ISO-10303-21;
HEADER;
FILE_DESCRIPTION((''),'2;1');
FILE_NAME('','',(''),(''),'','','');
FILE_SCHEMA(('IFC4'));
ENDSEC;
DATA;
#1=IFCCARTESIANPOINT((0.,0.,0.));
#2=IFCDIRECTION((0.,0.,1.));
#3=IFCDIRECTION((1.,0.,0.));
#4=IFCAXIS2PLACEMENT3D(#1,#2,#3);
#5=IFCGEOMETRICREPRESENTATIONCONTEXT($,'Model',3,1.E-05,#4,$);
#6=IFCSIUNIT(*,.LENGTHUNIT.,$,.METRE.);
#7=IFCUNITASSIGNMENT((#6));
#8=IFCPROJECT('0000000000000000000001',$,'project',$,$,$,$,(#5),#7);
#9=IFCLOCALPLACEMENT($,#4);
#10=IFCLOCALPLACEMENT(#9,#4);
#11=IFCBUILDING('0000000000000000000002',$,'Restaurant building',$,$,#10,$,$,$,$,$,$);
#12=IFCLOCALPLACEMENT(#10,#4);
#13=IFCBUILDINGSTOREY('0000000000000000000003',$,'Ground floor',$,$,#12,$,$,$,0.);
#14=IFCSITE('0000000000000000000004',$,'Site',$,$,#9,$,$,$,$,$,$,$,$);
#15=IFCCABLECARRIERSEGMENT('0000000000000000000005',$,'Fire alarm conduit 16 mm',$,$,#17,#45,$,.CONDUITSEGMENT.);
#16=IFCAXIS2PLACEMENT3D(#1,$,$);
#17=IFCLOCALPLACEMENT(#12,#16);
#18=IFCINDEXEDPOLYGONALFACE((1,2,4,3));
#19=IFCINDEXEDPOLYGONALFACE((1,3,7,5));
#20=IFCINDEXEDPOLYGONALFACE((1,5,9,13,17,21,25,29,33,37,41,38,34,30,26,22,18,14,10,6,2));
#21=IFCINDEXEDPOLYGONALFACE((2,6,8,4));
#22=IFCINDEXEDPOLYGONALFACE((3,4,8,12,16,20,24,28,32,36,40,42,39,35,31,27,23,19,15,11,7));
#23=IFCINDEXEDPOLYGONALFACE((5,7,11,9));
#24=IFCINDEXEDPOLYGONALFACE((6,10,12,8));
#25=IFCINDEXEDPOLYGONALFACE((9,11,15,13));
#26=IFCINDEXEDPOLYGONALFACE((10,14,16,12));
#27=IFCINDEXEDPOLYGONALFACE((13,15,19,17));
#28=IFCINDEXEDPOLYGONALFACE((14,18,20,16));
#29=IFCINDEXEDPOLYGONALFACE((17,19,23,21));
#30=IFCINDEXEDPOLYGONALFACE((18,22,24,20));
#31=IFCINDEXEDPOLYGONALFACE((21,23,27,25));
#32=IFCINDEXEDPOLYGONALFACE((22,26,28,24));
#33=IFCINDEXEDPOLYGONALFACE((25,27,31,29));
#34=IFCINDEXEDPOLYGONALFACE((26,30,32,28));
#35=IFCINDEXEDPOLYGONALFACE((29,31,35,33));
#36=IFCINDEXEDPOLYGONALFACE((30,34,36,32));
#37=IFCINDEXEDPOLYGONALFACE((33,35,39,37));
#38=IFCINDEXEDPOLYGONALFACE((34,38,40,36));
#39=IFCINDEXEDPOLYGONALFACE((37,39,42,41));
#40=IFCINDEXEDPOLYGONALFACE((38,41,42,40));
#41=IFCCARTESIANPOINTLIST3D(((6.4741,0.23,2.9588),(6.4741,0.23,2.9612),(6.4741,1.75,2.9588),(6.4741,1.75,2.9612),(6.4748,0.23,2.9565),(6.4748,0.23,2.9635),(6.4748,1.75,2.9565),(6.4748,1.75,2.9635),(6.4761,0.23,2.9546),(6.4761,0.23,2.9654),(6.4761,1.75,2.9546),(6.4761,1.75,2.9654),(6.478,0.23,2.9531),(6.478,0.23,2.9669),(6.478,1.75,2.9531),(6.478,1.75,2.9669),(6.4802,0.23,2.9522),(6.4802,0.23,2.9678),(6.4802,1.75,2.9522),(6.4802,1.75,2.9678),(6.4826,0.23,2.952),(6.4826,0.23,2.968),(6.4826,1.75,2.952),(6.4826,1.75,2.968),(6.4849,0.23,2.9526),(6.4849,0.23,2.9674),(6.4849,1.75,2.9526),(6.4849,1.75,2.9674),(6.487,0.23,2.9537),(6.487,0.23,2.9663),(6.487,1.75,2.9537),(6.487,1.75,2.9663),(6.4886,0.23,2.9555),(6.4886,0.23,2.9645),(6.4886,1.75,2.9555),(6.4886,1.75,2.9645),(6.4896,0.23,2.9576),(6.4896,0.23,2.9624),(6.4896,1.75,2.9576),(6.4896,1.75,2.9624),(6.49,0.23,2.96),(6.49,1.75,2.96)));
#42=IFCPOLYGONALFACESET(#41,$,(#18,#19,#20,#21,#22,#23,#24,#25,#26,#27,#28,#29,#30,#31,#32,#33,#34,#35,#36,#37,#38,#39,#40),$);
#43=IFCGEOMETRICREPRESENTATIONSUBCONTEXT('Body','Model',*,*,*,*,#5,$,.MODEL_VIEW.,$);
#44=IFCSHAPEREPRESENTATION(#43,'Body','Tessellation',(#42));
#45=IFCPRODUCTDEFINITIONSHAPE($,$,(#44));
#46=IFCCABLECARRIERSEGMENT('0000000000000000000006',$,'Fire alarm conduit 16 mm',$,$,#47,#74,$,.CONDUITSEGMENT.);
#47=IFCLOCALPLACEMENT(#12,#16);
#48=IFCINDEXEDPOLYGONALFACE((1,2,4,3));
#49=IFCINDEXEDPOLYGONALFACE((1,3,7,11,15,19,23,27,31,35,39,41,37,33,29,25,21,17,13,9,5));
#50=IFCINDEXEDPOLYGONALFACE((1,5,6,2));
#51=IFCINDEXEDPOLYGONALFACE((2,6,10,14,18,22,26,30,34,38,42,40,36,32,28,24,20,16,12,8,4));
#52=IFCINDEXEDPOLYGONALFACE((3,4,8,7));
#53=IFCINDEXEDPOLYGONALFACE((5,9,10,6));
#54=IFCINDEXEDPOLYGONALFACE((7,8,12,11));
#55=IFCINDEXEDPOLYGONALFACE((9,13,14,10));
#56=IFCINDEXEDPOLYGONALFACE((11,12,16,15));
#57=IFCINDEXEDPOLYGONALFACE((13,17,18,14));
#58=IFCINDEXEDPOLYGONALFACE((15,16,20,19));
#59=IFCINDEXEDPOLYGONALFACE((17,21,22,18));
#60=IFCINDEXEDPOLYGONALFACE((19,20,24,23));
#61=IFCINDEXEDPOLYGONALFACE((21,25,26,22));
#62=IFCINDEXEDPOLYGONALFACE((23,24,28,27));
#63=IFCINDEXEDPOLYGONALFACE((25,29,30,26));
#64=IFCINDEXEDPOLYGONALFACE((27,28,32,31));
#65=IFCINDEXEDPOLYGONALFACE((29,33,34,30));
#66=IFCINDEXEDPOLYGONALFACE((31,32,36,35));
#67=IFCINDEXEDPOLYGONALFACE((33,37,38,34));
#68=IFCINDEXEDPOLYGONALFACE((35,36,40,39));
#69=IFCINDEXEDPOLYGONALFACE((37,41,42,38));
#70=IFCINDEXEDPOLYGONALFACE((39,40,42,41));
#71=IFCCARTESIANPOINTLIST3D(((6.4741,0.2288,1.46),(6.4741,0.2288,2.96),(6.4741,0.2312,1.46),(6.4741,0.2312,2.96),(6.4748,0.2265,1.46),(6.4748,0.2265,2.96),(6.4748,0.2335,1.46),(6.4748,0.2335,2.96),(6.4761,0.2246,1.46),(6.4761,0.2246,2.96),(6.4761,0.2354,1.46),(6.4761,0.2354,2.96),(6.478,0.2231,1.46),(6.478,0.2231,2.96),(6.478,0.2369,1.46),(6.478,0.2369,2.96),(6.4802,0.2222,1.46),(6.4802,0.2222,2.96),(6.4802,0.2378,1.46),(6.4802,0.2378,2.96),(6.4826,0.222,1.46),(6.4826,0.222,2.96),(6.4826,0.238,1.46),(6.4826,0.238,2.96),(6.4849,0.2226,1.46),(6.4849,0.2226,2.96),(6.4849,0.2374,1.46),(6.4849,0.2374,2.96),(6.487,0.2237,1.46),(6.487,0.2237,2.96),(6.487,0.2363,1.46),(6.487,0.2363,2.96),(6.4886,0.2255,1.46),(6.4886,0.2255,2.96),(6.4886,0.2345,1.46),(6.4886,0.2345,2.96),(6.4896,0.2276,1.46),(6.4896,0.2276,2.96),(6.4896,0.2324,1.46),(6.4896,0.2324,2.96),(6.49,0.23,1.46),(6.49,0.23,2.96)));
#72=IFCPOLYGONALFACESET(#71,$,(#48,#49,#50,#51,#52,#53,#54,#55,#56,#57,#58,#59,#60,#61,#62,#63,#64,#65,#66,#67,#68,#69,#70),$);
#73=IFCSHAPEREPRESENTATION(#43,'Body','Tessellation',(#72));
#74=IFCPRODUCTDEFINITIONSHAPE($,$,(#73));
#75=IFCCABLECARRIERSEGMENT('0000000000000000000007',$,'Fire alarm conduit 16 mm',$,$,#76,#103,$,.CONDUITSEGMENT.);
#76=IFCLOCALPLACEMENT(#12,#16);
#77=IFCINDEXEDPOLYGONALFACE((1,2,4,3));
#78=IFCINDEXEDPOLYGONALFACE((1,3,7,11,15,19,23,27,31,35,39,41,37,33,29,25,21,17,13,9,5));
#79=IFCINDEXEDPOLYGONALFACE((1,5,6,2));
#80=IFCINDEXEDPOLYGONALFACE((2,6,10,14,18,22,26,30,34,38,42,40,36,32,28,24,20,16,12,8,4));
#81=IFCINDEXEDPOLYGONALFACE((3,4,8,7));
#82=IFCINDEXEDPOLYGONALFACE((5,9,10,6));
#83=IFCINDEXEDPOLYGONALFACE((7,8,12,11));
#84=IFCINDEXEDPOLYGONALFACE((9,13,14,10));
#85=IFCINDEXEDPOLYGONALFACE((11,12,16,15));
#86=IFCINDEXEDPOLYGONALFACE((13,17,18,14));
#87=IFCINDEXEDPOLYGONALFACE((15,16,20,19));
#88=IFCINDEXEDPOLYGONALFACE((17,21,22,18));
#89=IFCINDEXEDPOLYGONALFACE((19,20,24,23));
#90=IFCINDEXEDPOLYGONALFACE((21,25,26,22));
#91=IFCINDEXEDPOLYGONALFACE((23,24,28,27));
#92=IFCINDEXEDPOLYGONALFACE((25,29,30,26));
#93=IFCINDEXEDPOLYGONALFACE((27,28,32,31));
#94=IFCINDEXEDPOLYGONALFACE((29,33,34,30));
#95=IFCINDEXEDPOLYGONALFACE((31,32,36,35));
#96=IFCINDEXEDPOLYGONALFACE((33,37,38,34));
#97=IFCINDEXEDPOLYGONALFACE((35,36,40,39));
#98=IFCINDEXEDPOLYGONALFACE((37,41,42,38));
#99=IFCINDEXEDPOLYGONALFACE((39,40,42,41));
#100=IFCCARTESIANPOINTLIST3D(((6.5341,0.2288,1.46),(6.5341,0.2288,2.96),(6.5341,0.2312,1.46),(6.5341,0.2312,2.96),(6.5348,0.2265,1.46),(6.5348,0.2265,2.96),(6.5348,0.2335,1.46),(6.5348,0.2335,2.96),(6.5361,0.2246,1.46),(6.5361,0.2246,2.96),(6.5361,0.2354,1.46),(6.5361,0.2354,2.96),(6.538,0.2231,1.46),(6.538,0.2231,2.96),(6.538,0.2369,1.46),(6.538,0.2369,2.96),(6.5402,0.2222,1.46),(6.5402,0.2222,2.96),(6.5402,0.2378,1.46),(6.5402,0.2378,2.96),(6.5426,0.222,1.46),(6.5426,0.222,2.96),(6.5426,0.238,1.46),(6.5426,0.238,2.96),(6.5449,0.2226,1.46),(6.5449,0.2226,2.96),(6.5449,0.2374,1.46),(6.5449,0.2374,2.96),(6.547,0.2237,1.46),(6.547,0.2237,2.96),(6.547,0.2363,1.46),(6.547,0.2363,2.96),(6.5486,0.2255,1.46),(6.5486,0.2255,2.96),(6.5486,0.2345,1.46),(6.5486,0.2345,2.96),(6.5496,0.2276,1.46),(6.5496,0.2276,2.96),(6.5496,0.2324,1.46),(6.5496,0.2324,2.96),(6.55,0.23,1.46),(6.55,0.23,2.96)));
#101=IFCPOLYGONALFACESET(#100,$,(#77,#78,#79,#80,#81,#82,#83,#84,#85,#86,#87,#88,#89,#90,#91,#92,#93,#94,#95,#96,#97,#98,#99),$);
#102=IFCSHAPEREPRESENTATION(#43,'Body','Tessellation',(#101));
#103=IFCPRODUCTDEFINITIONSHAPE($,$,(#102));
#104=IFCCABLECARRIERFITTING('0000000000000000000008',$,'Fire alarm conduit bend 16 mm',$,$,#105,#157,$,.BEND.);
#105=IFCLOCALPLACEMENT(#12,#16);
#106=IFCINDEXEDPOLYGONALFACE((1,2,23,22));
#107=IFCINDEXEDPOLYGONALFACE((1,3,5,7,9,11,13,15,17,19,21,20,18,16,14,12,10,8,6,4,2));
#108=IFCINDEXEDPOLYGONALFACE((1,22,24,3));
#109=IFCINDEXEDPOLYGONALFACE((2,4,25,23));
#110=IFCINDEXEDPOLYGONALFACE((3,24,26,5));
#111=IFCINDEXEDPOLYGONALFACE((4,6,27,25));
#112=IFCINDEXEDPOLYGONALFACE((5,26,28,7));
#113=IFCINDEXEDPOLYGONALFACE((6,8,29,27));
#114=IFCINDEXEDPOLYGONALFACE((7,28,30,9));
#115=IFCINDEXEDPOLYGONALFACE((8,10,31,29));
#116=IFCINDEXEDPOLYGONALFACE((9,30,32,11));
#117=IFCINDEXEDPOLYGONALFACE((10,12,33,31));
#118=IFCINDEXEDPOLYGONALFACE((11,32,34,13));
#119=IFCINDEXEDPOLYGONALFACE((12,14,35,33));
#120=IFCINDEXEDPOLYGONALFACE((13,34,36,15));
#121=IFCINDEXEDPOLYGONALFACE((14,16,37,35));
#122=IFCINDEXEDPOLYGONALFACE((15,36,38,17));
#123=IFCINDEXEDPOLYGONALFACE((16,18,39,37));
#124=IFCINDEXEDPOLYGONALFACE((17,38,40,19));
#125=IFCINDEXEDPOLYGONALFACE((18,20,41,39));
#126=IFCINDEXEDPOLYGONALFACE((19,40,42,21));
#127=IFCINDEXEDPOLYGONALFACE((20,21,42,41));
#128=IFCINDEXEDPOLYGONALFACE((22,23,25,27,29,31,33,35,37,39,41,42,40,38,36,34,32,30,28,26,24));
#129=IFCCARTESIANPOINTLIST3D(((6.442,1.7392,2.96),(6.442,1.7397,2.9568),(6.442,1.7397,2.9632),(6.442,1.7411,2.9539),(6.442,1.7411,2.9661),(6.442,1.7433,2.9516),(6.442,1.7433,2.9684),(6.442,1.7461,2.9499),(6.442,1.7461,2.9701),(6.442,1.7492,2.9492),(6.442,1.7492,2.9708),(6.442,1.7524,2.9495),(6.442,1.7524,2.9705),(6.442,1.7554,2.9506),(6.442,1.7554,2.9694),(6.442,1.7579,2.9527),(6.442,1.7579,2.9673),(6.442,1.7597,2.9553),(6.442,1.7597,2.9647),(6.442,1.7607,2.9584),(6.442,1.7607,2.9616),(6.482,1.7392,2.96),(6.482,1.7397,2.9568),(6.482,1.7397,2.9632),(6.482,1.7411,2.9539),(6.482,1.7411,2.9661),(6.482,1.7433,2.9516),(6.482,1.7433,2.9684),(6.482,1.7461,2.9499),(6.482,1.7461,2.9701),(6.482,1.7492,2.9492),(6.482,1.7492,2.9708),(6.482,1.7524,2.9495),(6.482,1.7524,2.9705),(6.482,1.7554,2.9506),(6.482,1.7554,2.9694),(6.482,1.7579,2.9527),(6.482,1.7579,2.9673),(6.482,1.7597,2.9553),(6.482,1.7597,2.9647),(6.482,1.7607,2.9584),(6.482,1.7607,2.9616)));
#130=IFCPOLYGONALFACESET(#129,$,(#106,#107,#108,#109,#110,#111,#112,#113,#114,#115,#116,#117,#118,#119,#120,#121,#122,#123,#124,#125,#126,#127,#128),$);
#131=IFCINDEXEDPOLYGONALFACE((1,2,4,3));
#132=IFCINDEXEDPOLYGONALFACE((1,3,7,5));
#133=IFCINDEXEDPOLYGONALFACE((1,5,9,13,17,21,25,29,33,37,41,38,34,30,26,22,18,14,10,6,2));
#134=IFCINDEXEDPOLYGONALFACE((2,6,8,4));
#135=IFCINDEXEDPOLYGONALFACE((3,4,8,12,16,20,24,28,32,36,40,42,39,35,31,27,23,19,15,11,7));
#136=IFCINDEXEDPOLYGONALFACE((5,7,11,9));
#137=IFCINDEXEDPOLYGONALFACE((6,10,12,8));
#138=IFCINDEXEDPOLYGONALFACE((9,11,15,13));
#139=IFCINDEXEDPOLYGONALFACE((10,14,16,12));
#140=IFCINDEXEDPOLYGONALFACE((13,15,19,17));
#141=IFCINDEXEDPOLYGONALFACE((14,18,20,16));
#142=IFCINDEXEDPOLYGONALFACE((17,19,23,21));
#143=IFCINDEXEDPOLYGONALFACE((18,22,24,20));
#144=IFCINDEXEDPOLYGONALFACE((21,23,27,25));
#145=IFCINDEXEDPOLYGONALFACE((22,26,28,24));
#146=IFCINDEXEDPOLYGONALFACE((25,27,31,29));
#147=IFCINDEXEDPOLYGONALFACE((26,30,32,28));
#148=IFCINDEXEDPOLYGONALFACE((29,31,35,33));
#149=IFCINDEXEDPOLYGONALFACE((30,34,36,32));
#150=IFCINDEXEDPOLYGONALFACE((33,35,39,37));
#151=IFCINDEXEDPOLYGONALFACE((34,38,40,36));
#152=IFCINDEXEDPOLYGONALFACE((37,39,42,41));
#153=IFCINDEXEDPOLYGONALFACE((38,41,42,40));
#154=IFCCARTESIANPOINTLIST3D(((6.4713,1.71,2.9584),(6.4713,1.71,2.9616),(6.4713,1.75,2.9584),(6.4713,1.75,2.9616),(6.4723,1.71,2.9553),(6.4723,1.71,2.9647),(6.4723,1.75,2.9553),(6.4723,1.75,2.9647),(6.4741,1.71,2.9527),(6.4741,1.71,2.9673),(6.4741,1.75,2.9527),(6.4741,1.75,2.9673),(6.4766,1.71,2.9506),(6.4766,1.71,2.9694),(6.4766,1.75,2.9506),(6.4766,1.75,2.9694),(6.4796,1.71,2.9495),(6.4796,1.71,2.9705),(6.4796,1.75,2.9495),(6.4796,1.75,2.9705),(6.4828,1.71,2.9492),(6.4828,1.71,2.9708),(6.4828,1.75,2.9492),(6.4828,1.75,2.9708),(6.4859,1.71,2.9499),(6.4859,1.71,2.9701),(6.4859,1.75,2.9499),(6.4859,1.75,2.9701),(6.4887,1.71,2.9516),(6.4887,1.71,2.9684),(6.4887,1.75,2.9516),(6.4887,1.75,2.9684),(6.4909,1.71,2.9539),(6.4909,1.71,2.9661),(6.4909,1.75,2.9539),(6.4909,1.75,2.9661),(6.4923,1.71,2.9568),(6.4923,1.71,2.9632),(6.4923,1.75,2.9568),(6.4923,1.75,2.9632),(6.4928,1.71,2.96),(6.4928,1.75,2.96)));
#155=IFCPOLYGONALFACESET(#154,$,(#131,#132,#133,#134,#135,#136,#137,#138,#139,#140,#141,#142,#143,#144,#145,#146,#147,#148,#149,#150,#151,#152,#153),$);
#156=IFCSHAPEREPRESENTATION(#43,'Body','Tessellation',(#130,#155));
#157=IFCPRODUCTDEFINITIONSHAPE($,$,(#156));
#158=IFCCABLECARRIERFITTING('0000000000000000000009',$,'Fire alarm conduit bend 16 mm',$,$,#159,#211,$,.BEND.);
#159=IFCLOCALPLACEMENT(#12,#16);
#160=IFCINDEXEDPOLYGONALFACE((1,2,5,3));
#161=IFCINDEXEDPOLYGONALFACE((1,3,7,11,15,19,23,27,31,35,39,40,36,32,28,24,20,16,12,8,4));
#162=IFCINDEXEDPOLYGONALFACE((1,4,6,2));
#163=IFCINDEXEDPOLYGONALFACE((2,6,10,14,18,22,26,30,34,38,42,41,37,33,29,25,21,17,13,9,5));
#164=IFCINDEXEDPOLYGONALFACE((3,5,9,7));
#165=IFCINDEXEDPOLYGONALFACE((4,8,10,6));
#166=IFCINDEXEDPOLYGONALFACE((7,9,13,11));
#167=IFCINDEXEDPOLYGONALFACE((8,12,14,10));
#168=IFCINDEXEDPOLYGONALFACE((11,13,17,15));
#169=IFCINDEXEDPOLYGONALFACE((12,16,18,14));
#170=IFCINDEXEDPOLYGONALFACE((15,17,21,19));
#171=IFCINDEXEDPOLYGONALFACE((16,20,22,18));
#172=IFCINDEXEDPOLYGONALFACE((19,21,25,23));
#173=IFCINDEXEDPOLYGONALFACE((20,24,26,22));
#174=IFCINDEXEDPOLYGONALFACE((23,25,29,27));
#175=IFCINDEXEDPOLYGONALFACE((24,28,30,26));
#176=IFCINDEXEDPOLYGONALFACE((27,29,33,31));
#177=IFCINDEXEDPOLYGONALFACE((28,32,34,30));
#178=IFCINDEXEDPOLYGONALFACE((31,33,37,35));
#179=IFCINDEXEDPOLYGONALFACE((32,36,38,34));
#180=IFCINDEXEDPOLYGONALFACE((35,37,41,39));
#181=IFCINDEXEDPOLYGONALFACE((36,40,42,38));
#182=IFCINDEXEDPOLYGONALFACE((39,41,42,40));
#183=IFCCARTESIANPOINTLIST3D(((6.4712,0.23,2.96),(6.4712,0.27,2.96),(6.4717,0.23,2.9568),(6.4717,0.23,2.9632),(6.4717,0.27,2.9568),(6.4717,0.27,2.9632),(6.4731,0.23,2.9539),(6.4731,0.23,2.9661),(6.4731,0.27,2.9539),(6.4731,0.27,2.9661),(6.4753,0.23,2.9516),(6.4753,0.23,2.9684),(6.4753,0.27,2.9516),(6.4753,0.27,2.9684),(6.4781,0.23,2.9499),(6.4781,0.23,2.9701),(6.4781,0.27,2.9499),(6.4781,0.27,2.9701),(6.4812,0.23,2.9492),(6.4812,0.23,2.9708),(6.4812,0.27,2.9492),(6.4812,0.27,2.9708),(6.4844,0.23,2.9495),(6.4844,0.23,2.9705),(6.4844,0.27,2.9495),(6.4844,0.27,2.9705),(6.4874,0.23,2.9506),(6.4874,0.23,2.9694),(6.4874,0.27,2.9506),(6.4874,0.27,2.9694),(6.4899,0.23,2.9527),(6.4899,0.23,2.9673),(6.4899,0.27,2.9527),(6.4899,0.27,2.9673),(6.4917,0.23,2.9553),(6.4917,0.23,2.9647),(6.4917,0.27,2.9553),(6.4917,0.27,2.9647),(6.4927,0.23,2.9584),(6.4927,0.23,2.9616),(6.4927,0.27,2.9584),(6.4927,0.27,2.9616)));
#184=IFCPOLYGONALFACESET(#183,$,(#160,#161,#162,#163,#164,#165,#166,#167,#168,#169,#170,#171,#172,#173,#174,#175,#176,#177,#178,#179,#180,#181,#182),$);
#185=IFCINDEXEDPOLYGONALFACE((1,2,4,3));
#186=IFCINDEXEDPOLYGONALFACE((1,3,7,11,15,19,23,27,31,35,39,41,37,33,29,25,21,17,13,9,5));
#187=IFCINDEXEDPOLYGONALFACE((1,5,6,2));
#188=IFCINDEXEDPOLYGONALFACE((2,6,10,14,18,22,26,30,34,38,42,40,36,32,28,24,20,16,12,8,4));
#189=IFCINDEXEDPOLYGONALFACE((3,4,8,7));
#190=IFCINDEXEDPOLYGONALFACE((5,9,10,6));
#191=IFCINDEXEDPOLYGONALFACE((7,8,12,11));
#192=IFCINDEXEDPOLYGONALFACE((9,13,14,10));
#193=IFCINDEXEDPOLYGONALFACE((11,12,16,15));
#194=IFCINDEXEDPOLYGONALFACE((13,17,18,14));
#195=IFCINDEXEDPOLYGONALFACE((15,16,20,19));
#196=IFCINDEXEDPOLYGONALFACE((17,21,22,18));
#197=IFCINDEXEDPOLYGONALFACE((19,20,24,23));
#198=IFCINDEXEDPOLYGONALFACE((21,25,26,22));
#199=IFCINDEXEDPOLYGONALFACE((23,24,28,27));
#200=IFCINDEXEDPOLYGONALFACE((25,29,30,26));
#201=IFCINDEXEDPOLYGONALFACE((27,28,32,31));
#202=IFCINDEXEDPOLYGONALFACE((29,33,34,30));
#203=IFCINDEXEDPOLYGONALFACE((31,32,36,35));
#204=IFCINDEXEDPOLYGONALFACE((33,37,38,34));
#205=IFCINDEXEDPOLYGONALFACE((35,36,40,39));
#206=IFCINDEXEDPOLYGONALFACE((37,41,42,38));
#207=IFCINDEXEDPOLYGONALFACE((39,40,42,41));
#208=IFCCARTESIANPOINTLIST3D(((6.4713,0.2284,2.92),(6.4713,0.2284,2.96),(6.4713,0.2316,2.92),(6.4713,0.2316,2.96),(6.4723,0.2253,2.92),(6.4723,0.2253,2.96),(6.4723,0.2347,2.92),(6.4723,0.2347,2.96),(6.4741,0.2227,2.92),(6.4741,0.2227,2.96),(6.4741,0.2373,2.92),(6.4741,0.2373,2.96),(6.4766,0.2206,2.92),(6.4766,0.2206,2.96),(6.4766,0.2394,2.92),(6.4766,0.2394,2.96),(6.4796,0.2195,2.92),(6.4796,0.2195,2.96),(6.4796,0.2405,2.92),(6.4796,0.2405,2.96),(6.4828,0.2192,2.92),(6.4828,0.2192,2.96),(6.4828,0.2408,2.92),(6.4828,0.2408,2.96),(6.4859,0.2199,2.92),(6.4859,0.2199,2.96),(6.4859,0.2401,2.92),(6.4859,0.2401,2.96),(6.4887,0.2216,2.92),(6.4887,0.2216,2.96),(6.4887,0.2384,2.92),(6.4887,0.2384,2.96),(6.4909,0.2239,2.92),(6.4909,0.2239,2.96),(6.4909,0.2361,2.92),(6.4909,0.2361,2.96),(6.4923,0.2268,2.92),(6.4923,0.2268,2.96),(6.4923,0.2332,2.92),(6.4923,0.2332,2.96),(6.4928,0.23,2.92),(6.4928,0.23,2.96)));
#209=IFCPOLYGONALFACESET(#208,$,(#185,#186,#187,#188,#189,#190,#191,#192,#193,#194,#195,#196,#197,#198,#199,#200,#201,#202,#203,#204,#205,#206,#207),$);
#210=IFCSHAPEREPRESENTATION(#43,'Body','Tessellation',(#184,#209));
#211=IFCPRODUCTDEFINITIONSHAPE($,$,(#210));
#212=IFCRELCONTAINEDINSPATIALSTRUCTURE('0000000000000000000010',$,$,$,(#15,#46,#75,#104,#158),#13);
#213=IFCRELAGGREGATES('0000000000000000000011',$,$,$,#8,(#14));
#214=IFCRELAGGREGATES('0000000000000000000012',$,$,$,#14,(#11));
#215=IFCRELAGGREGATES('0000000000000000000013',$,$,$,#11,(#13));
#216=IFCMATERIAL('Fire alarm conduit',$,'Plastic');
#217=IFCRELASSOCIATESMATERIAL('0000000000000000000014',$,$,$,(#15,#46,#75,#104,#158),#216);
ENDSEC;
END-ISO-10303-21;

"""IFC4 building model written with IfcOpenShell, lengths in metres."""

from ifc_helpers import new_model, si_unit, frame, origin, origin_with_axes, origin_2d, place, context, subcontext, project, spatial, circle, extrude, material, element, save


model = new_model("IFC4")

# Units and contexts
model_context = context("Model", 3, precision=1e-05, world=origin_with_axes())
body_context = subcontext(model_context, "Body", "Model", "MODEL_VIEW")
ifc_project = project(units=[si_unit("LENGTHUNIT", "METRE")], contexts=[model_context])

# Site, building, storey
site_placement = place(None, origin_with_axes())
site = spatial("IfcSite", under=ifc_project, at=site_placement, Name="Site")
building_placement = place(site_placement, origin_with_axes())
building = spatial("IfcBuilding", under=site, at=building_placement, Name="Restaurant building")
storey_placement = place(building_placement, origin_with_axes())
storey = spatial("IfcBuildingStorey", under=building, at=storey_placement, Name="Ground floor", Elevation=0.0)

# Cable carrier segments
ifc_material_1 = material(Name="Fire alarm conduit", Category="Plastic")
cable_carrier_segment_1_placement = place(storey_placement, frame((6.482, 1.75, 2.96)))
element("IfcCableCarrierSegment", 1, at=cable_carrier_segment_1_placement, inside=storey, material=ifc_material_1, Name="Fire alarm conduit 16 mm", PredefinedType="CONDUITSEGMENT", context=body_context, shape_type="SweptSolid", body=[
    extrude(circle(Radius=0.008, at=origin_2d()), frame((0.0, 0.0, 0.0), z_axis=(0.0, -1.0, 0.0), x_axis=(1.0, 0.0, 0.0)), (0.0, 0.0, 1.0), 1.52),
])
cable_carrier_segment_2_placement = place(storey_placement, frame((6.482, 0.23, 2.96)))
element("IfcCableCarrierSegment", 2, at=cable_carrier_segment_2_placement, inside=storey, material=ifc_material_1, Name="Fire alarm conduit 16 mm", PredefinedType="CONDUITSEGMENT", context=body_context, shape_type="SweptSolid", body=[
    extrude(circle(Radius=0.008, at=origin_2d()), frame((0.0, 0.0, 0.0), z_axis=(0.0, 0.0, -1.0), x_axis=(1.0, 0.0, 0.0)), (0.0, 0.0, 1.0), 1.5),
])
cable_carrier_segment_3_placement = place(storey_placement, frame((6.542, 0.23, 1.46)))
element("IfcCableCarrierSegment", 3, at=cable_carrier_segment_3_placement, inside=storey, material=ifc_material_1, Name="Fire alarm conduit 16 mm", PredefinedType="CONDUITSEGMENT", context=body_context, shape_type="SweptSolid", body=[
    extrude(circle(Radius=0.008, at=origin_2d()), origin(), (0.0, 0.0, 1.0), 1.5),
])

# Cable carrier fittings
cable_carrier_fitting_1_placement = place(storey_placement, frame((6.482, 1.75, 2.96)))
element("IfcCableCarrierFitting", 4, at=cable_carrier_fitting_1_placement, inside=storey, material=ifc_material_1, Name="Fire alarm conduit bend 16 mm", PredefinedType="BEND", context=body_context, shape_type="SweptSolid", body=[
    extrude(circle(Radius=0.0108, at=origin_2d()), frame((0.0, 0.0, 0.0), z_axis=(-1.0, 0.0, 0.0), x_axis=(0.0, -1.0, 0.0)), (0.0, 0.0, 1.0), 0.04),
    extrude(circle(Radius=0.0108, at=origin_2d()), frame((0.0, 0.0, 0.0), z_axis=(0.0, -1.0, 0.0), x_axis=(1.0, 0.0, 0.0)), (0.0, 0.0, 1.0), 0.04),
])
cable_carrier_fitting_2_placement = place(storey_placement, frame((6.482, 0.23, 2.96)))
element("IfcCableCarrierFitting", 5, at=cable_carrier_fitting_2_placement, inside=storey, material=ifc_material_1, Name="Fire alarm conduit bend 16 mm", PredefinedType="BEND", context=body_context, shape_type="SweptSolid", body=[
    extrude(circle(Radius=0.0108, at=origin_2d()), frame((0.0, 0.0, 0.0), z_axis=(0.0, 1.0, 0.0), x_axis=(-1.0, 0.0, 0.0)), (0.0, 0.0, 1.0), 0.04),
    extrude(circle(Radius=0.0108, at=origin_2d()), frame((0.0, 0.0, 0.0), z_axis=(0.0, 0.0, -1.0), x_axis=(1.0, 0.0, 0.0)), (0.0, 0.0, 1.0), 0.04),
])

save(model, "model.ifc")
